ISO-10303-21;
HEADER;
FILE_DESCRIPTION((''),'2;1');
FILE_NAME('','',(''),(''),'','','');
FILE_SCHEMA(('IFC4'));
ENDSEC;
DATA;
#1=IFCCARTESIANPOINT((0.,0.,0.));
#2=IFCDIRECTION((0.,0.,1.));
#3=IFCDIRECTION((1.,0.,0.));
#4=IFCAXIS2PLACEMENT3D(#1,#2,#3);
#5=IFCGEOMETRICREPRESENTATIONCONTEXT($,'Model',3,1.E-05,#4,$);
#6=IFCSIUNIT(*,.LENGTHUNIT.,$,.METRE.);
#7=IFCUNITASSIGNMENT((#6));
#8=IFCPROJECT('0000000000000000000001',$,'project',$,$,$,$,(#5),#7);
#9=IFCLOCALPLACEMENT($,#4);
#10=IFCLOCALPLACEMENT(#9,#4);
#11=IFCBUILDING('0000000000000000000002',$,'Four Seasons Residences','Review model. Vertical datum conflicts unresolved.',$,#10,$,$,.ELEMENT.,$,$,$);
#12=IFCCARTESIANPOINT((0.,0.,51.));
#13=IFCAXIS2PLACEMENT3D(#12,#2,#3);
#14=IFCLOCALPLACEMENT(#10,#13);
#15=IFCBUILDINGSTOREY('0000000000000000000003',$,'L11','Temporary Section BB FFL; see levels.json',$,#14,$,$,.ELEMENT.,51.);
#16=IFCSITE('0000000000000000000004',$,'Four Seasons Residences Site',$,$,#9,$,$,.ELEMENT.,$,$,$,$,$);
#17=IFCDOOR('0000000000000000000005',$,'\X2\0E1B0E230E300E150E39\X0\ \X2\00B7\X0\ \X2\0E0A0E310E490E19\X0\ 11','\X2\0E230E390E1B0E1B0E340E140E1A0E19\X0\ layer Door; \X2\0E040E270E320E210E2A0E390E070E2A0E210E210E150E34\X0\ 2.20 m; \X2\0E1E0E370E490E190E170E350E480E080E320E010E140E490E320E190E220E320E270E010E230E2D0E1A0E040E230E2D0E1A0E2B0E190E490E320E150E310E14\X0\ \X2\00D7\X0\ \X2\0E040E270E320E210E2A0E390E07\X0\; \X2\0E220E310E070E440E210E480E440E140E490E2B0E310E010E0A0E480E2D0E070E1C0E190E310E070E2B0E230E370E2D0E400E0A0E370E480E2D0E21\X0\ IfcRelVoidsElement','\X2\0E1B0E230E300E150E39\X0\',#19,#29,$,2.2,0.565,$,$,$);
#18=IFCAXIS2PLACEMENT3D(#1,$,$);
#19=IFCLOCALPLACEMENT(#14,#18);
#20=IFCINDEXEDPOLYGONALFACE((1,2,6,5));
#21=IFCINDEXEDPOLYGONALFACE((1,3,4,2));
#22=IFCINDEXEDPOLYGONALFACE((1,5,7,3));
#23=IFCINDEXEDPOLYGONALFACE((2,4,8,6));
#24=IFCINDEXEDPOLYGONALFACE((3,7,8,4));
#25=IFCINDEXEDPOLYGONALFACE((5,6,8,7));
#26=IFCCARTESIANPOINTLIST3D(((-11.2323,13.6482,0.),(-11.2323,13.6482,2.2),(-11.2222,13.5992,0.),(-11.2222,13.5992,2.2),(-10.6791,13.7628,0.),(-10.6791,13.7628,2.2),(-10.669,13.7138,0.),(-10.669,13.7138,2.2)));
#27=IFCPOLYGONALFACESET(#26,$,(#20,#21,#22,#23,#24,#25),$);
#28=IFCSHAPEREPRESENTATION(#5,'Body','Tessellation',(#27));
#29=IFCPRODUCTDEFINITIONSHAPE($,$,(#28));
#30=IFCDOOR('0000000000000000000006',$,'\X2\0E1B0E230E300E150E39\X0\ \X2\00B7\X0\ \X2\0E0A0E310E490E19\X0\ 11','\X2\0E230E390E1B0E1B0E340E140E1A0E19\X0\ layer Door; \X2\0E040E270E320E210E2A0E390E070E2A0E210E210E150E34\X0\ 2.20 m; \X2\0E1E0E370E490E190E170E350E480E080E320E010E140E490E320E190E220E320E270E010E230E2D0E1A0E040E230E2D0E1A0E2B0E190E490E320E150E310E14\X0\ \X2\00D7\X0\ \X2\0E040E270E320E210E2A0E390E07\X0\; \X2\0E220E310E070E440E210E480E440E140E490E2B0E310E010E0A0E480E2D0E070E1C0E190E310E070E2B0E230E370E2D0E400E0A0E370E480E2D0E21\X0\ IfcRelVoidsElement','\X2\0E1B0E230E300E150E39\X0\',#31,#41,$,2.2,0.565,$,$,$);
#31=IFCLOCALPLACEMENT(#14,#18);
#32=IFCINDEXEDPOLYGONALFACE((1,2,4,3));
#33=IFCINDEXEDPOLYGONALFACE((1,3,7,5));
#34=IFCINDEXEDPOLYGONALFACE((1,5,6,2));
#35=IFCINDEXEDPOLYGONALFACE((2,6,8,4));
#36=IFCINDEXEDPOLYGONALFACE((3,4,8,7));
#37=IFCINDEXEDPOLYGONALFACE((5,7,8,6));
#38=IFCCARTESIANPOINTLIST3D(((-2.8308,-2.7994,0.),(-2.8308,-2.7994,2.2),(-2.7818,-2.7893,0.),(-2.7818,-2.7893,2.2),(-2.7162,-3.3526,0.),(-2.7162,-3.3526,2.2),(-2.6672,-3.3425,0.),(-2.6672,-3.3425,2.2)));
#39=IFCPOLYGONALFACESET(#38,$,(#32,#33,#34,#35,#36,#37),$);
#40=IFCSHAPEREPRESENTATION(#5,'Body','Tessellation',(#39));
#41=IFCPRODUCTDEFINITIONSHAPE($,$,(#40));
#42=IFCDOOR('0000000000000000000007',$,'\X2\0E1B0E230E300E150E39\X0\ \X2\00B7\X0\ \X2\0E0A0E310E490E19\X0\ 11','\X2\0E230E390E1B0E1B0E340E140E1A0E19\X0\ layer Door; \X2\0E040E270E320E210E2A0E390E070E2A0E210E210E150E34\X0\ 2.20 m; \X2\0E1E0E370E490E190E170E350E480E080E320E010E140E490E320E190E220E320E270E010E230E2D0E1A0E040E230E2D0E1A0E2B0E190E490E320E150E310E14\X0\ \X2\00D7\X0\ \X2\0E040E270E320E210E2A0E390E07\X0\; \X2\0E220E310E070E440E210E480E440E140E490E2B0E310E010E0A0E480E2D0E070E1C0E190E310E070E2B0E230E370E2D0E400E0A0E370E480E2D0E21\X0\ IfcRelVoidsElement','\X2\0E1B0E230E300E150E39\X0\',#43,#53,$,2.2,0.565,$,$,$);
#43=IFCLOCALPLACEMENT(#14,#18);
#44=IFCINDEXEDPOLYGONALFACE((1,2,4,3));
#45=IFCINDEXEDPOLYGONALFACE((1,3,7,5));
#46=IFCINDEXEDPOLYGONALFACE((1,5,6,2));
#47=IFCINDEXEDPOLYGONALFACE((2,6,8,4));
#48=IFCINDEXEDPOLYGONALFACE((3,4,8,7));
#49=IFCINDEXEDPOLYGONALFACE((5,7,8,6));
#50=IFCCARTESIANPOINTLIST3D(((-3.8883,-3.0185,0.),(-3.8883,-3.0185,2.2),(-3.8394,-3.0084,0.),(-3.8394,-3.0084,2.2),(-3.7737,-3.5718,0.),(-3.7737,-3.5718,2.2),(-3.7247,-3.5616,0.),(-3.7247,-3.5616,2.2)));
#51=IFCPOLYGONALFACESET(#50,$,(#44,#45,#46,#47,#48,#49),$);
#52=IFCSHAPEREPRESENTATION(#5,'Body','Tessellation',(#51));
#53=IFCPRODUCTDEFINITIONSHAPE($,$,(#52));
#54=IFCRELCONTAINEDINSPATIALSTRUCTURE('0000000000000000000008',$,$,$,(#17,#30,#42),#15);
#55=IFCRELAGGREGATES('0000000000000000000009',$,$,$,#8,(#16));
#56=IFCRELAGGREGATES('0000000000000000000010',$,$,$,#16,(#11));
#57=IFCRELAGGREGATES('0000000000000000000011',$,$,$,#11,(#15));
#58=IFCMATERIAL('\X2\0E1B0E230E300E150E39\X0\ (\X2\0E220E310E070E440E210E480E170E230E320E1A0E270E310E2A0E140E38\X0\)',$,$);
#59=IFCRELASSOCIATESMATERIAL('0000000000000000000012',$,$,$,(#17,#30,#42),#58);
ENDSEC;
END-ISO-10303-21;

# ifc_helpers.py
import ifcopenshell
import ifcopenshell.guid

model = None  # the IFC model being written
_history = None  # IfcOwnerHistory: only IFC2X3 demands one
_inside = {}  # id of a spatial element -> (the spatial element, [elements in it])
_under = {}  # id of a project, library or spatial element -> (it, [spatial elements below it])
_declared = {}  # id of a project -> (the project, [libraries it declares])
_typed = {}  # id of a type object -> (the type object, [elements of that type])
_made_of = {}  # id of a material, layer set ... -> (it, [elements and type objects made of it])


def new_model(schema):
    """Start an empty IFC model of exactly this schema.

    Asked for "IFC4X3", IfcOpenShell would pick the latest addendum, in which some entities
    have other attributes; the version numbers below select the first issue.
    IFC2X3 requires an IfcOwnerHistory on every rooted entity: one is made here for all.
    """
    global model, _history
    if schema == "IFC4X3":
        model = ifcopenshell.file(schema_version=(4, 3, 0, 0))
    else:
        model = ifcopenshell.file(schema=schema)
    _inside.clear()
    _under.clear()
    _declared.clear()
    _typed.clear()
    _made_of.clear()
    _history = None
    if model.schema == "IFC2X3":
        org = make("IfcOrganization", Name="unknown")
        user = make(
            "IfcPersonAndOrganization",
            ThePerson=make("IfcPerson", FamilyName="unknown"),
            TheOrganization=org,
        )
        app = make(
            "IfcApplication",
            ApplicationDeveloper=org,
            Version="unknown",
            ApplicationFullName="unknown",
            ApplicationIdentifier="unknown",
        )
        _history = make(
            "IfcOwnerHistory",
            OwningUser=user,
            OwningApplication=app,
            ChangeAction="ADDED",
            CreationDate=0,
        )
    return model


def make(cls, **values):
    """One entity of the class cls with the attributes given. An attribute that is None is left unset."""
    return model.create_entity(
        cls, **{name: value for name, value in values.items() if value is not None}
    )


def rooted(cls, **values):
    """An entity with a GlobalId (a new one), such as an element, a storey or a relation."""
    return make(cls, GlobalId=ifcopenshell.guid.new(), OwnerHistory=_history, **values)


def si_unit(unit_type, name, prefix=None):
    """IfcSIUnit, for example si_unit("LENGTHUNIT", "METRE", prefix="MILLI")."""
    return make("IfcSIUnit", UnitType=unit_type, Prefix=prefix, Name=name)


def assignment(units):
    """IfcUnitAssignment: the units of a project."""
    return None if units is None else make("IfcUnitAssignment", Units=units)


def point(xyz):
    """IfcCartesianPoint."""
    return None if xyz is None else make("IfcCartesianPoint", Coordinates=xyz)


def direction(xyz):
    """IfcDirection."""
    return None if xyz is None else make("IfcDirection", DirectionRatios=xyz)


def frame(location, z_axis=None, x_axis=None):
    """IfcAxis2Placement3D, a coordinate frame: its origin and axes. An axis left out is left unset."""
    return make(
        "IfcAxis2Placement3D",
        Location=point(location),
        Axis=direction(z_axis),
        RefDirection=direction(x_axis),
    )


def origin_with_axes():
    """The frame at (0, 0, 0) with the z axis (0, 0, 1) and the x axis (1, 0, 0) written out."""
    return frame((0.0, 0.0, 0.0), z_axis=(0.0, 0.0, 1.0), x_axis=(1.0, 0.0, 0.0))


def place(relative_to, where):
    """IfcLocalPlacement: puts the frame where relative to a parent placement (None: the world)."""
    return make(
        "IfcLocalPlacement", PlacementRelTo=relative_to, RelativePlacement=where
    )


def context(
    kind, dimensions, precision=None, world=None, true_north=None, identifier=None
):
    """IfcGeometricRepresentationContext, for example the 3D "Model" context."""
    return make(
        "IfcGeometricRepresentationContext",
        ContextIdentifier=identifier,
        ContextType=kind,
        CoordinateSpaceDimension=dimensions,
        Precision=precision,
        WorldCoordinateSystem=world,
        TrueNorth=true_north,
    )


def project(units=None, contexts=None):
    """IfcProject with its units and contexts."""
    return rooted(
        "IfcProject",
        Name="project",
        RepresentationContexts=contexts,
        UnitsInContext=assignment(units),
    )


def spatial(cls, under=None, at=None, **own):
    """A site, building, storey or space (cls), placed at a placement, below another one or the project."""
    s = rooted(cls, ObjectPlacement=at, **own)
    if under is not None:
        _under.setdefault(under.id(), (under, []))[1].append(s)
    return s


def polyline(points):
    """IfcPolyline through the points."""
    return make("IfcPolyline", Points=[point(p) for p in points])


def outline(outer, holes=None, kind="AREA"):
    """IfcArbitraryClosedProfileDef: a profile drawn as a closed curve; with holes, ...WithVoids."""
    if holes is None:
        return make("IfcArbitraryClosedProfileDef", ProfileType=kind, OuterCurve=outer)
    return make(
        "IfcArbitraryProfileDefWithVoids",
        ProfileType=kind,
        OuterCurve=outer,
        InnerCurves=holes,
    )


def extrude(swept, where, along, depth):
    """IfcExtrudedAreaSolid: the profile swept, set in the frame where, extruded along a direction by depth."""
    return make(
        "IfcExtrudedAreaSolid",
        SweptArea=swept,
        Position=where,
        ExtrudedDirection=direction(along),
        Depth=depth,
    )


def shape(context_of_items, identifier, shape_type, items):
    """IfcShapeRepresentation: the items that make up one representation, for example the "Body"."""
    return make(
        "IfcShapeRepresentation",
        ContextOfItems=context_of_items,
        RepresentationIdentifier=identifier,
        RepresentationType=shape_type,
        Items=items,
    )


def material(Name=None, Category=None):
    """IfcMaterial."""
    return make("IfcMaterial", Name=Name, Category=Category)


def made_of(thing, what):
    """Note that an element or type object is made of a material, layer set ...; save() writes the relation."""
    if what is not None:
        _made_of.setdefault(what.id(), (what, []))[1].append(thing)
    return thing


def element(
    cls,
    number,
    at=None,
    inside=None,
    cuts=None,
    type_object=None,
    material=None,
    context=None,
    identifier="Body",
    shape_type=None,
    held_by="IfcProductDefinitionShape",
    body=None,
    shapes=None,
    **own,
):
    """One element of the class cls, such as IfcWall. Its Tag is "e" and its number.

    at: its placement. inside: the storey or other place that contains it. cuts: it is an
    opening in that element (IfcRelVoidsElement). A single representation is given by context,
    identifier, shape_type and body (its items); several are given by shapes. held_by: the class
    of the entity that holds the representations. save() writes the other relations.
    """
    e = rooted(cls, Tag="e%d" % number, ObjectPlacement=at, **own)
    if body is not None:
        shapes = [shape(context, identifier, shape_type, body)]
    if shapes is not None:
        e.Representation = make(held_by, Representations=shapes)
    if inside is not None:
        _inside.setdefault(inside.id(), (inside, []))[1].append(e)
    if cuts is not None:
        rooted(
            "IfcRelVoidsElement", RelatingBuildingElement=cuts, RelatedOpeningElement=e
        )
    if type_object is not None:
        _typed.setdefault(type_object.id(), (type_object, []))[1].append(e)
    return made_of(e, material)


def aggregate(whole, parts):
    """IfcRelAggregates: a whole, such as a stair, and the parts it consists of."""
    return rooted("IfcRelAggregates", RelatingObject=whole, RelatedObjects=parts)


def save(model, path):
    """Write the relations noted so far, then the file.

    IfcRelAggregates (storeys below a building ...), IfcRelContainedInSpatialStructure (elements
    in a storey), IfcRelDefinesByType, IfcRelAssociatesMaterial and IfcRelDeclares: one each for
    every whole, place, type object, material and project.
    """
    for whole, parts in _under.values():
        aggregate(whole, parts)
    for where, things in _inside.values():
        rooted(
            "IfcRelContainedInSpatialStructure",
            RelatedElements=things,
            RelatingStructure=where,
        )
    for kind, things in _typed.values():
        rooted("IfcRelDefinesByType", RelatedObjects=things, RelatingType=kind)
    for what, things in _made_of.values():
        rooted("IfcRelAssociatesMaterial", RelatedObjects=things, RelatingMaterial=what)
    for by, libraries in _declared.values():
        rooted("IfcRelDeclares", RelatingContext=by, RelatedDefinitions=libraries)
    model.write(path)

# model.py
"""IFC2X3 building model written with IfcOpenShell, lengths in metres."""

from ifc_helpers import new_model, si_unit, frame, origin_with_axes, place, context, project, spatial, polyline, outline, extrude, material, element, save


model = new_model("IFC2X3")

# Units and contexts
model_context = context("Model", 3, precision=1e-05, world=origin_with_axes())
ifc_project = project(units=[si_unit("LENGTHUNIT", "METRE")], contexts=[model_context])

# Site, building, storey
site_placement = place(None, origin_with_axes())
site = spatial("IfcSite", under=ifc_project, at=site_placement, Name="Four Seasons Residences Site", CompositionType="ELEMENT")
building_placement = place(site_placement, origin_with_axes())
building = spatial("IfcBuilding", under=site, at=building_placement, Name="Four Seasons Residences", Description="Review model. Vertical datum conflicts unresolved.", CompositionType="ELEMENT")
storey_placement = place(building_placement, frame((0.0, 0.0, 51.0), z_axis=(0.0, 0.0, 1.0), x_axis=(1.0, 0.0, 0.0)))
storey = spatial("IfcBuildingStorey", under=building, at=storey_placement, Name="L11", Description="Temporary Section BB FFL; see levels.json", CompositionType="ELEMENT", Elevation=51.0)

# Doors
ifc_material_1 = material(Name="ประตู (ยังไม่ทราบวัสดุ)")
door_1_placement = place(storey_placement, origin_with_axes())
element("IfcDoor", 1, at=door_1_placement, inside=storey, material=ifc_material_1, Name="ประตู · ชั้น 11", Description="รูปปิดบน layer Door; ความสูงสมมติ 2.20 m; พื้นที่จากด้านยาวกรอบครอบหน้าตัด × ความสูง; ยังไม่ได้หักช่องผนังหรือเชื่อม IfcRelVoidsElement", ObjectType="ประตู", OverallHeight=2.2, OverallWidth=0.565, context=model_context, shape_type="SweptSolid", body=[
    extrude(outline(polyline([(-11.2323, 13.6482), (-10.6791, 13.7628), (-10.669, 13.7138), (-11.2222, 13.5992), (-11.2323, 13.6482)])), origin_with_axes(), (0.0, 0.0, 1.0), 2.2),
])
door_2_placement = place(storey_placement, origin_with_axes())
element("IfcDoor", 2, at=door_2_placement, inside=storey, material=ifc_material_1, Name="ประตู · ชั้น 11", Description="รูปปิดบน layer Door; ความสูงสมมติ 2.20 m; พื้นที่จากด้านยาวกรอบครอบหน้าตัด × ความสูง; ยังไม่ได้หักช่องผนังหรือเชื่อม IfcRelVoidsElement", ObjectType="ประตู", OverallHeight=2.2, OverallWidth=0.565, context=model_context, shape_type="SweptSolid", body=[
    extrude(outline(polyline([(-2.7818, -2.7893), (-2.6672, -3.3425), (-2.7162, -3.3526), (-2.8308, -2.7994), (-2.7818, -2.7893)])), origin_with_axes(), (0.0, 0.0, 1.0), 2.2),
])
door_3_placement = place(storey_placement, origin_with_axes())
element("IfcDoor", 3, at=door_3_placement, inside=storey, material=ifc_material_1, Name="ประตู · ชั้น 11", Description="รูปปิดบน layer Door; ความสูงสมมติ 2.20 m; พื้นที่จากด้านยาวกรอบครอบหน้าตัด × ความสูง; ยังไม่ได้หักช่องผนังหรือเชื่อม IfcRelVoidsElement", ObjectType="ประตู", OverallHeight=2.2, OverallWidth=0.565, context=model_context, shape_type="SweptSolid", body=[
    extrude(outline(polyline([(-3.8883, -3.0185), (-3.7737, -3.5718), (-3.7247, -3.5616), (-3.8394, -3.0084), (-3.8883, -3.0185)])), origin_with_axes(), (0.0, 0.0, 1.0), 2.2),
])

save(model, "model.ifc")
